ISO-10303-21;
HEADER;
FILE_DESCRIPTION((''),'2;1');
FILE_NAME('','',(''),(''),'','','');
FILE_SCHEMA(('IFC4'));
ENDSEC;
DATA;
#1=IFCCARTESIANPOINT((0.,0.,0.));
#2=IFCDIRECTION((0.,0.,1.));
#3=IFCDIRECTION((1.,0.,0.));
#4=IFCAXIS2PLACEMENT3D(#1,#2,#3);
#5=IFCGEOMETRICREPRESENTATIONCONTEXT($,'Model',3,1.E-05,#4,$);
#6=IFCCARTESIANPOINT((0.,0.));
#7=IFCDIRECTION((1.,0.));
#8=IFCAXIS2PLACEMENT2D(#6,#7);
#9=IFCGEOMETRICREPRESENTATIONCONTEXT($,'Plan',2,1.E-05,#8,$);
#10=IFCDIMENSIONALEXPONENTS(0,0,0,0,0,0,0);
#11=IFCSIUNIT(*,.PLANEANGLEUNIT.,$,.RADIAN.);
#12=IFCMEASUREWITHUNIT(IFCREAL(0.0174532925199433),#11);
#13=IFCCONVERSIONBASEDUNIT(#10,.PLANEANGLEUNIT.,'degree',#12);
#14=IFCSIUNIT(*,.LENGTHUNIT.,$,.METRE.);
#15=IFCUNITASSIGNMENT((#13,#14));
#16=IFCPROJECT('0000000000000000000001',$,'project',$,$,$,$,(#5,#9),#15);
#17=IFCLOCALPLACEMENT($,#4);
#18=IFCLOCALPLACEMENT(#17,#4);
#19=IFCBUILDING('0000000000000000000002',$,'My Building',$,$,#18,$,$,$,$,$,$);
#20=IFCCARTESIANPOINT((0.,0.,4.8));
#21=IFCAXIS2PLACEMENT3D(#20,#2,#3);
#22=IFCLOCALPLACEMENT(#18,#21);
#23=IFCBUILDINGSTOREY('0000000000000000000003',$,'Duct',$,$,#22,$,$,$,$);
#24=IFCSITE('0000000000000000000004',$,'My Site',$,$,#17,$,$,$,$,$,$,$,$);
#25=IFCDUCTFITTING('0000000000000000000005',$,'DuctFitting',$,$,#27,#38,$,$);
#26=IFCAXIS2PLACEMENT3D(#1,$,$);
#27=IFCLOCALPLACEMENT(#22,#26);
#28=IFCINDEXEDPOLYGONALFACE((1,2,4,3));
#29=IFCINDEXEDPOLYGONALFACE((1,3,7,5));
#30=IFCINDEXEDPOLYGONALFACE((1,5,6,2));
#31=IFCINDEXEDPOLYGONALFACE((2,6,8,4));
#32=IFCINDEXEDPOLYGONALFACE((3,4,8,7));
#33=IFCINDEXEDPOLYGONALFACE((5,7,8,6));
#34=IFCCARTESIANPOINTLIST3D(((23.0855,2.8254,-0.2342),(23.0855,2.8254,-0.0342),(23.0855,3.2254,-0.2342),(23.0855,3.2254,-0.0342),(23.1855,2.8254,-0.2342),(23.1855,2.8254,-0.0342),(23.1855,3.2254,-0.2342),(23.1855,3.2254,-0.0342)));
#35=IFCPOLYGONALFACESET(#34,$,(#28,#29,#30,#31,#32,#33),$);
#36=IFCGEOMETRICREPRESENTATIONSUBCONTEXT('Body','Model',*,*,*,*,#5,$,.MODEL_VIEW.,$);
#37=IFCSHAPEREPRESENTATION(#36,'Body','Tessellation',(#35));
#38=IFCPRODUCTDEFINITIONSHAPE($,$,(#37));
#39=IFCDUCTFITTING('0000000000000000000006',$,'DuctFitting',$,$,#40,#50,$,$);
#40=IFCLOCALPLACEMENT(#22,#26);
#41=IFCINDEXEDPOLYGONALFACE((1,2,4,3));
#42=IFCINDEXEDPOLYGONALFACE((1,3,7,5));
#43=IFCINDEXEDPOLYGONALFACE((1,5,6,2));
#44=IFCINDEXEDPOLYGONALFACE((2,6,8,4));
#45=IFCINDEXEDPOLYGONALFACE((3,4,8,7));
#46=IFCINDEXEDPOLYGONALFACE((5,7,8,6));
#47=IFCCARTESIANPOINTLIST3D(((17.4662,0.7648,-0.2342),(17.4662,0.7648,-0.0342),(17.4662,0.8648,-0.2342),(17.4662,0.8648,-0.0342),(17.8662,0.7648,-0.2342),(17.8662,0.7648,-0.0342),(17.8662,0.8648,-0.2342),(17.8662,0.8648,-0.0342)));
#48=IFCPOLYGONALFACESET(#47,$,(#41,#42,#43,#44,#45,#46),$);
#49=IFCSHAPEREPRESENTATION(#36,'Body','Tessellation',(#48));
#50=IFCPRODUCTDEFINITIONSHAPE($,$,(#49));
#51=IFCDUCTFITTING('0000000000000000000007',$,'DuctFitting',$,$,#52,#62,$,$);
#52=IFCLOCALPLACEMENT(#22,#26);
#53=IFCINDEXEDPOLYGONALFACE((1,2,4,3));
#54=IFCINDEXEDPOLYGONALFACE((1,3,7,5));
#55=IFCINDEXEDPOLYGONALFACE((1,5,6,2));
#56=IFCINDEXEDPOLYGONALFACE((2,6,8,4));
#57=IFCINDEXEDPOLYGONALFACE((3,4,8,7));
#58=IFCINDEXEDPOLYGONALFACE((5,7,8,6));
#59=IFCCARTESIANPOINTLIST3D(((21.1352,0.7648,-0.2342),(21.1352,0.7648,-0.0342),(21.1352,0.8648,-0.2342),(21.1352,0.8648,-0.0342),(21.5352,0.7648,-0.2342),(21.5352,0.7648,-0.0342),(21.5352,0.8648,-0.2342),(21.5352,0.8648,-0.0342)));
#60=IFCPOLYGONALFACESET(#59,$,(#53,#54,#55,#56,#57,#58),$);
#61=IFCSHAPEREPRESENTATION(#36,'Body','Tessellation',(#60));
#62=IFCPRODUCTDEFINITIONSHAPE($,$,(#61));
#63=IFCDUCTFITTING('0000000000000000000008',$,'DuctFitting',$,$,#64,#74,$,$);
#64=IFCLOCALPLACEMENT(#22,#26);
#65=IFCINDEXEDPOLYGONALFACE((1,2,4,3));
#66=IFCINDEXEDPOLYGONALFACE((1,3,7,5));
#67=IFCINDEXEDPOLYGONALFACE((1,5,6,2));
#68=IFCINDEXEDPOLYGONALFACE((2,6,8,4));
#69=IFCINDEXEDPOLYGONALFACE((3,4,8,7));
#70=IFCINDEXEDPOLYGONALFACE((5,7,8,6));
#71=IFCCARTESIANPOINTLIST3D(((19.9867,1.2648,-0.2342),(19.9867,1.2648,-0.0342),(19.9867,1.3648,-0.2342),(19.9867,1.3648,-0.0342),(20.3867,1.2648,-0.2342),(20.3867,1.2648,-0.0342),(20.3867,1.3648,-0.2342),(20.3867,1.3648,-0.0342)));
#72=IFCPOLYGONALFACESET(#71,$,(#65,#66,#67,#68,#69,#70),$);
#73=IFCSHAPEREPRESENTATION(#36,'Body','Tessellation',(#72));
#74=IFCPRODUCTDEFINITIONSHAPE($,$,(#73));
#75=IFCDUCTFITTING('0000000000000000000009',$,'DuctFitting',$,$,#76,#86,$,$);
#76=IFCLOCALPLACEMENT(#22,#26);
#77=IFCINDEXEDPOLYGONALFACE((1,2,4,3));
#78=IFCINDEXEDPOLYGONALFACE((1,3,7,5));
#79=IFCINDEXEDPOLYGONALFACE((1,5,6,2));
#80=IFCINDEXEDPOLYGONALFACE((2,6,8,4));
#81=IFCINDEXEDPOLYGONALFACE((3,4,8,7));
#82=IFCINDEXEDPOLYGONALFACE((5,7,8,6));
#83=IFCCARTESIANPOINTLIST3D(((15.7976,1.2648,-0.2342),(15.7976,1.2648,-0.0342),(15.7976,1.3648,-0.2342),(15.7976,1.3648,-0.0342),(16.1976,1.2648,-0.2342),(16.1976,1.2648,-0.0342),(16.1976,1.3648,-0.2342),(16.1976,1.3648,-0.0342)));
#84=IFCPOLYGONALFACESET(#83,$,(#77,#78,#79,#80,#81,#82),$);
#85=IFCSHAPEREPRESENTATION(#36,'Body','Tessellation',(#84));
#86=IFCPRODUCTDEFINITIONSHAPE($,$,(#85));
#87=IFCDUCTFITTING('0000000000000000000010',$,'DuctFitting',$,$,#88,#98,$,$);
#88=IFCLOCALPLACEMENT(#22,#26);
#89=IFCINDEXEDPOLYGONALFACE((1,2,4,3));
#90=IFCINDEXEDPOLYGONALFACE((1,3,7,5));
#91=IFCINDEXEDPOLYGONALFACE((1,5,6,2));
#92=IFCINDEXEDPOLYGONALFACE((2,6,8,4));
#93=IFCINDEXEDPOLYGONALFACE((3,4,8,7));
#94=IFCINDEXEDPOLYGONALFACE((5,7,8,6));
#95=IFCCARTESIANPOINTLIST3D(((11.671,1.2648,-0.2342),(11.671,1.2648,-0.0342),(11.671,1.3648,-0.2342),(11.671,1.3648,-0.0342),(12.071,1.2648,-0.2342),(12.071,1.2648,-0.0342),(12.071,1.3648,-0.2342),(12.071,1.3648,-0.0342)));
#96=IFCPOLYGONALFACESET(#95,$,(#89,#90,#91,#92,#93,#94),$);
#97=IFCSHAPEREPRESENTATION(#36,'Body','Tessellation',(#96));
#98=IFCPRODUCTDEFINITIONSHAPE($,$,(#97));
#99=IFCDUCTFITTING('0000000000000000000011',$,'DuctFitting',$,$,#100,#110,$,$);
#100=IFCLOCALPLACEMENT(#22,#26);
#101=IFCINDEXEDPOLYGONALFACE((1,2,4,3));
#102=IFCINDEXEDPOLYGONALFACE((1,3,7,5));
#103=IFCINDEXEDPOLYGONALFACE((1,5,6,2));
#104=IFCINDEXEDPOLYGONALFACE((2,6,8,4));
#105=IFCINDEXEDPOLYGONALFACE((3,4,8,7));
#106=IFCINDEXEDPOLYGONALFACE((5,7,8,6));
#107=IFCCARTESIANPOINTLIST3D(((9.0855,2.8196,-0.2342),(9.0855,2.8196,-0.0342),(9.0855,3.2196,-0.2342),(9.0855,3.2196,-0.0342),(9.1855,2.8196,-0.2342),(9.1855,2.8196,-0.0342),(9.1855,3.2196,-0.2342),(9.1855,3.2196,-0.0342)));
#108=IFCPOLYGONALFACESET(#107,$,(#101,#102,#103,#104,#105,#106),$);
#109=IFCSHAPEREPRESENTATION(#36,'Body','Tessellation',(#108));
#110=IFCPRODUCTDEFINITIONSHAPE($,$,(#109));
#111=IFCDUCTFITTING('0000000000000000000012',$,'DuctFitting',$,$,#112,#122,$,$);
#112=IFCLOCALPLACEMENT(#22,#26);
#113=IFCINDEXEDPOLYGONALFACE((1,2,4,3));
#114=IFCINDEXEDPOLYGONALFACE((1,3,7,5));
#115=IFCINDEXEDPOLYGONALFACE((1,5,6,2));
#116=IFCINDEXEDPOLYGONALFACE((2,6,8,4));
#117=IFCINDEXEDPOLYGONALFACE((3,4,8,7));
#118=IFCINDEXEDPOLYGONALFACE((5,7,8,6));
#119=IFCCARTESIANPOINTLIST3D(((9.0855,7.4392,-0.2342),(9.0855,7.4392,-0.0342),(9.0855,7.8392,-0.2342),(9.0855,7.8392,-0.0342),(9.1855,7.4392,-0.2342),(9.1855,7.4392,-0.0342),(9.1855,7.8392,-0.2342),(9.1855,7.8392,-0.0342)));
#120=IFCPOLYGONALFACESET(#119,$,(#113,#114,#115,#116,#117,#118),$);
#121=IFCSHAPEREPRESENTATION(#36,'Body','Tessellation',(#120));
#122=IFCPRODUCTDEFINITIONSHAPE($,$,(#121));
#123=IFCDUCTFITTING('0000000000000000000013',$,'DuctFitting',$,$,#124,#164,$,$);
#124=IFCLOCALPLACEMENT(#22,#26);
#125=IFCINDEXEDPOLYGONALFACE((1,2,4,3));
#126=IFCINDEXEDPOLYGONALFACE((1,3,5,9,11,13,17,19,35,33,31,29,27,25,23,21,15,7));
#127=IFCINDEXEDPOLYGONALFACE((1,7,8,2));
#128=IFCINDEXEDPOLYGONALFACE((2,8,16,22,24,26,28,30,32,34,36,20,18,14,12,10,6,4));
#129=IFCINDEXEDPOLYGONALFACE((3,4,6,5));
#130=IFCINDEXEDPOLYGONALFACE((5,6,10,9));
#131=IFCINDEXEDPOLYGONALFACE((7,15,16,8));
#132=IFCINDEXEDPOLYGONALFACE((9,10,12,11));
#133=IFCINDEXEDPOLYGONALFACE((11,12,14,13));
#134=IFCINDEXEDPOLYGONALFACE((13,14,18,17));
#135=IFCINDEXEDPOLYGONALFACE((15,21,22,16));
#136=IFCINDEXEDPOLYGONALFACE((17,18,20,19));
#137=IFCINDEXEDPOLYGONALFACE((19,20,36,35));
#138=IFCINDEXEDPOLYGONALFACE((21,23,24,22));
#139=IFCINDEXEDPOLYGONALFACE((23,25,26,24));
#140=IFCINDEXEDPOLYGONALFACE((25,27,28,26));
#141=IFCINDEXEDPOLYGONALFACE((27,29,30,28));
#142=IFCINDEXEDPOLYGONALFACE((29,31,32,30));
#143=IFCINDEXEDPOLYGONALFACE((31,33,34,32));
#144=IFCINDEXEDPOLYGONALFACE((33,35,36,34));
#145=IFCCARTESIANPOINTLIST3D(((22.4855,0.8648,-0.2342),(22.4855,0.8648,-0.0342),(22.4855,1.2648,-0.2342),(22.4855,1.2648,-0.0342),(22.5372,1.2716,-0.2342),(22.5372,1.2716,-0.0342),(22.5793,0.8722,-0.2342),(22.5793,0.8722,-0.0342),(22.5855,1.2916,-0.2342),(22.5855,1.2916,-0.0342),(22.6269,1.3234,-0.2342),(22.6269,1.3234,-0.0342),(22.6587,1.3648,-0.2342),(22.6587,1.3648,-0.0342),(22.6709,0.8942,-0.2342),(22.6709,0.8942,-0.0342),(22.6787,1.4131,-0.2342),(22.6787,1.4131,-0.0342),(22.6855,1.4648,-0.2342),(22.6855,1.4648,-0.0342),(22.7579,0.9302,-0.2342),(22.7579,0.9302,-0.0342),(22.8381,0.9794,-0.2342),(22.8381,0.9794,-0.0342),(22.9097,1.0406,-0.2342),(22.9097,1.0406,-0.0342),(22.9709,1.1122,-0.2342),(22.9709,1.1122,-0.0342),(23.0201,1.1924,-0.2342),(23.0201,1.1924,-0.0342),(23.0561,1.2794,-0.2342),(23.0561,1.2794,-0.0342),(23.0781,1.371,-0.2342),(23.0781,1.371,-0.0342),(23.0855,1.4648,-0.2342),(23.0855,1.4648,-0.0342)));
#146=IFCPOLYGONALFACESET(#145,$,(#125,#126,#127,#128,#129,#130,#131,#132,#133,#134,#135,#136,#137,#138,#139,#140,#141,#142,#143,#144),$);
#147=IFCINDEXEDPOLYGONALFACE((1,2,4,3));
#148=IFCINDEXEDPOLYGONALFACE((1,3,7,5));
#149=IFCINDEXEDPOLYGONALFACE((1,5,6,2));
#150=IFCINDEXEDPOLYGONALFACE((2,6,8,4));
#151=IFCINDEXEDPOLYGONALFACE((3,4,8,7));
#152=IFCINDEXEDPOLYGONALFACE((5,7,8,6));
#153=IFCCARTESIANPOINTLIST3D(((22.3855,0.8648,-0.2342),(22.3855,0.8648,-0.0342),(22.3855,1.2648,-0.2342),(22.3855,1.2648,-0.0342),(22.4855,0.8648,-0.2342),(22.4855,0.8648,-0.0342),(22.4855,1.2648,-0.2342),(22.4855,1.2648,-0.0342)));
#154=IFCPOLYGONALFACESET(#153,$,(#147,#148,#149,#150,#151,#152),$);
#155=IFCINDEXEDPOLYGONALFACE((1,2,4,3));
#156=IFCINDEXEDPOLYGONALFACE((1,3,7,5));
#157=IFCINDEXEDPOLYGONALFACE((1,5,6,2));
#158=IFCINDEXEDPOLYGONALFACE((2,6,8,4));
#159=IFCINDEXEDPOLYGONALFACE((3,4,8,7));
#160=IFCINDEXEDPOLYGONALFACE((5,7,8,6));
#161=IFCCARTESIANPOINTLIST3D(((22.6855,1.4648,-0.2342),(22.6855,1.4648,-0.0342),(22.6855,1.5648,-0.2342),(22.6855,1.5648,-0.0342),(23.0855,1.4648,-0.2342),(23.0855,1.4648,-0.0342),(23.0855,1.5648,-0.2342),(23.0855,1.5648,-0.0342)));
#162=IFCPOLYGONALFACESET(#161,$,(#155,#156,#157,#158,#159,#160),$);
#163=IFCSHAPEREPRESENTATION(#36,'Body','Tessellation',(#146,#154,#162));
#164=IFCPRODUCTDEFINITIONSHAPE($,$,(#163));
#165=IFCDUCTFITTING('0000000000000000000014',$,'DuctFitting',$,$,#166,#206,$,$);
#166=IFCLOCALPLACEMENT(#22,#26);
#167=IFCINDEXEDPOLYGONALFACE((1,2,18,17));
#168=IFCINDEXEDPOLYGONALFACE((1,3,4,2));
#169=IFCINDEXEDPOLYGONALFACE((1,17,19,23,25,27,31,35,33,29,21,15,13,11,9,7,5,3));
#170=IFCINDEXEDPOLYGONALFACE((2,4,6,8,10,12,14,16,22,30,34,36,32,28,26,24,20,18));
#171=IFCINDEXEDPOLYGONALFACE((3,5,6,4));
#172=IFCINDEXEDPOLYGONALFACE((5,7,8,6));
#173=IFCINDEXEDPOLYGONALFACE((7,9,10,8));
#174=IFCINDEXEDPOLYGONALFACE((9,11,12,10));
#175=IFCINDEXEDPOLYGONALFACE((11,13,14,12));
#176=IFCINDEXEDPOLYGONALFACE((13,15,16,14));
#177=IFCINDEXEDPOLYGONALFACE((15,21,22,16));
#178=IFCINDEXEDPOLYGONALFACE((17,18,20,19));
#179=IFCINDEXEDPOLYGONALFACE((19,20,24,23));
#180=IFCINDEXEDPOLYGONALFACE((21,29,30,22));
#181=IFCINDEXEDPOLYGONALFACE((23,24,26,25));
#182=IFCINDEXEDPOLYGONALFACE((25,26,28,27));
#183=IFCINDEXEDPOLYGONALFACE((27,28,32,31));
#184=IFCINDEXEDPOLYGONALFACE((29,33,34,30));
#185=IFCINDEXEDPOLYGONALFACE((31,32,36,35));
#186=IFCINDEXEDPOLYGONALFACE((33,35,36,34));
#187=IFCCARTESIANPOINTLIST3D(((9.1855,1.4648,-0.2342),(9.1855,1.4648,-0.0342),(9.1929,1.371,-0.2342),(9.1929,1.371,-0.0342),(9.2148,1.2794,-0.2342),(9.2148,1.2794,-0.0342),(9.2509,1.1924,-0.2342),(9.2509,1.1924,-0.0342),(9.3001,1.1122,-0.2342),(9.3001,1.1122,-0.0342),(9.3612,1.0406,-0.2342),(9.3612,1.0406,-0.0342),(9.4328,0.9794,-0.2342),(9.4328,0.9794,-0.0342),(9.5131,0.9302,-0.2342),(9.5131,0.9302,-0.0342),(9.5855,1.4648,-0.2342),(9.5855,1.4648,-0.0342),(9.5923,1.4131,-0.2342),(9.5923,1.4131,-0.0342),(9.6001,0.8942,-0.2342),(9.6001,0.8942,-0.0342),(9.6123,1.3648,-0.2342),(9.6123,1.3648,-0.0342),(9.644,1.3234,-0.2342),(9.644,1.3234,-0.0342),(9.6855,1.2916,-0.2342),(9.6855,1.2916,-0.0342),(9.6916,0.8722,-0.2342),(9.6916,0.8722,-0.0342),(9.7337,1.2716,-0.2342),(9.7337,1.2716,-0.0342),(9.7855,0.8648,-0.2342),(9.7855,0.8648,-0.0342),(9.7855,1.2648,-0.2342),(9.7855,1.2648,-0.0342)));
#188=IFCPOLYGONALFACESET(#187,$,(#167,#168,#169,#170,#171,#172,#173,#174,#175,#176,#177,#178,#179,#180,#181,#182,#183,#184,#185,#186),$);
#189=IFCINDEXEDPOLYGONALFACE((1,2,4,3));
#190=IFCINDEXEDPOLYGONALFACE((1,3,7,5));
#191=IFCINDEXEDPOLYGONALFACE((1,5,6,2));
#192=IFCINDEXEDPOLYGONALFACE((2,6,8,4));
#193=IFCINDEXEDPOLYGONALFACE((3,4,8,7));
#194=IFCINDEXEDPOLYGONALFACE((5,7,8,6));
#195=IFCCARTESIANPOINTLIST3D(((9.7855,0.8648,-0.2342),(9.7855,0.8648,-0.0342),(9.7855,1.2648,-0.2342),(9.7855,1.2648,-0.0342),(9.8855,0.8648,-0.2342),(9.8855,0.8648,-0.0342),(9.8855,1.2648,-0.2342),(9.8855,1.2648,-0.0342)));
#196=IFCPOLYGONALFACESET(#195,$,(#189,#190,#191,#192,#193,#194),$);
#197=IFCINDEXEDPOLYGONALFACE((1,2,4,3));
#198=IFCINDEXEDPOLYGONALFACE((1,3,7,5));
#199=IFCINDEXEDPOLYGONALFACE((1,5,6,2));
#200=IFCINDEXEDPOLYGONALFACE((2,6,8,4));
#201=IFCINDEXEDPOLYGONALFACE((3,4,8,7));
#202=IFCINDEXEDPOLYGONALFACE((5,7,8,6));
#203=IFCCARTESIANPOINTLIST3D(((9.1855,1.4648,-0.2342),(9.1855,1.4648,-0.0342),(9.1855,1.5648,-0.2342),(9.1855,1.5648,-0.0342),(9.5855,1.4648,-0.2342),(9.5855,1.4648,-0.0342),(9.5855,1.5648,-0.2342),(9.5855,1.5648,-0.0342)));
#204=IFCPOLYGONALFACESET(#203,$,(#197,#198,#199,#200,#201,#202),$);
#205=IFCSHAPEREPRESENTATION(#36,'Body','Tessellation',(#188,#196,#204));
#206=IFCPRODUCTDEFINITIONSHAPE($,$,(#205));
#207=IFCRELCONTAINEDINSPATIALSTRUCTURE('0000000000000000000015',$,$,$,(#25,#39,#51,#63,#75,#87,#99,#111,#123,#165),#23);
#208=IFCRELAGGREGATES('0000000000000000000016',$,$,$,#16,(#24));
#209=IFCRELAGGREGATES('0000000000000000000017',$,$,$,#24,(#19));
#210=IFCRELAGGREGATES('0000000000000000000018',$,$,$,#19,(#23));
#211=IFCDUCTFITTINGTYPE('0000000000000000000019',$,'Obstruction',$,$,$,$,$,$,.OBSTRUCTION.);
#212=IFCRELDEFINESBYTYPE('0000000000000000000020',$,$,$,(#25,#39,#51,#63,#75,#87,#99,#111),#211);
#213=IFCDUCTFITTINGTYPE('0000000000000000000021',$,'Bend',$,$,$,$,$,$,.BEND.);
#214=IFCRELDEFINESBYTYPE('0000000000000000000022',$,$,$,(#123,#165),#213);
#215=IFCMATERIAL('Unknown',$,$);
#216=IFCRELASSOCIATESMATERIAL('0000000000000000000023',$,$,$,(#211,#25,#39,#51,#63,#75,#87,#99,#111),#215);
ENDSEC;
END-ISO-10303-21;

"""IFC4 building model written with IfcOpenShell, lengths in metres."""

from ifc_helpers import new_model, entity, si_unit, converted_unit, frame, origin_with_axes, origin_2d_with_axis, place, context, subcontext, project, spatial, line, arc, indexed_curve, rectangle, outline, extrude, source, transform, mapped, material, material_profile, profile_set, profile_usage, type_object, type_shapes, element, save


model = new_model("IFC4")

# Units and contexts
model_context = context("Model", 3, precision=1e-05, world=origin_with_axes())
plan_context = context("Plan", 2, precision=1e-05, world=origin_2d_with_axis())
body_context = subcontext(model_context, "Body", "Model", "MODEL_VIEW")
ifc_project = project(units=[converted_unit("PLANEANGLEUNIT", "degree", entity("IfcReal", 0.0174532925199433), si_unit("PLANEANGLEUNIT", "RADIAN"), dimensions=[0, 0, 0, 0, 0, 0, 0]), si_unit("LENGTHUNIT", "METRE")], contexts=[model_context, plan_context])

# Site, building, storey
site_placement = place(None, origin_with_axes())
site = spatial("IfcSite", under=ifc_project, at=site_placement, Name="My Site")
building_placement = place(site_placement, origin_with_axes())
building = spatial("IfcBuilding", under=site, at=building_placement, Name="My Building")
storey_placement = place(building_placement, frame((0.0, 0.0, 4.8), z_axis=(0.0, 0.0, 1.0), x_axis=(1.0, 0.0, 0.0)))
storey = spatial("IfcBuildingStorey", under=building, at=storey_placement, Name="Duct")

# Shared definitions
ifc_material = material(Name="Unknown")

# Duct fittings
ifc_material_profile_1 = material_profile(ifc_material, rectangle(XDim=0.4, YDim=0.2))
ifc_profile_set_1 = profile_set([ifc_material_profile_1])
duct_fitting_type_1 = type_object("IfcDuctFittingType", Name="Obstruction", PredefinedType="OBSTRUCTION", material=ifc_profile_set_1)
ifc_profile_usage_1 = profile_usage(ifc_profile_set_1, cardinal=5)
duct_fitting_1_placement = place(storey_placement, frame((23.0855, 3.0254, -0.1342), z_axis=(1.0, -0.000001, 0.000001), x_axis=(0.000001, 1.0, 0.0)))
element("IfcDuctFitting", 1, at=duct_fitting_1_placement, inside=storey, type_object=duct_fitting_type_1, material=ifc_profile_usage_1, Name="DuctFitting", context=body_context, shape_type="SweptSolid", body=[
    extrude(rectangle(XDim=0.4, YDim=0.2), origin_with_axes(), (0.0, 0.0, 1.0), 0.1),
])
ifc_profile_usage_2 = profile_usage(ifc_profile_set_1, cardinal=5)
duct_fitting_2_placement = place(storey_placement, frame((17.6662, 0.8648, -0.1342), z_axis=(0.0, -1.0, -0.000001), x_axis=(1.0, 0.0, 0.0)))
element("IfcDuctFitting", 2, at=duct_fitting_2_placement, inside=storey, type_object=duct_fitting_type_1, material=ifc_profile_usage_2, Name="DuctFitting", context=body_context, shape_type="SweptSolid", body=[
    extrude(rectangle(XDim=0.4, YDim=0.2), origin_with_axes(), (0.0, 0.0, 1.0), 0.1),
])
ifc_profile_usage_3 = profile_usage(ifc_profile_set_1, cardinal=5)
duct_fitting_3_placement = place(storey_placement, frame((21.3352, 0.8648, -0.1342), z_axis=(0.0, -1.0, -0.000001), x_axis=(1.0, 0.0, 0.0)))
element("IfcDuctFitting", 3, at=duct_fitting_3_placement, inside=storey, type_object=duct_fitting_type_1, material=ifc_profile_usage_3, Name="DuctFitting", context=body_context, shape_type="SweptSolid", body=[
    extrude(rectangle(XDim=0.4, YDim=0.2), origin_with_axes(), (0.0, 0.0, 1.0), 0.1),
])
ifc_profile_usage_4 = profile_usage(ifc_profile_set_1, cardinal=5)
duct_fitting_4_placement = place(storey_placement, frame((20.1867, 1.3648, -0.1342), z_axis=(0.000001, -1.0, 0.0), x_axis=(1.0, 0.000001, 0.0)))
element("IfcDuctFitting", 4, at=duct_fitting_4_placement, inside=storey, type_object=duct_fitting_type_1, material=ifc_profile_usage_4, Name="DuctFitting", context=body_context, shape_type="SweptSolid", body=[
    extrude(rectangle(XDim=0.4, YDim=0.2), origin_with_axes(), (0.0, 0.0, 1.0), 0.1),
])
ifc_profile_usage_5 = profile_usage(ifc_profile_set_1, cardinal=5)
duct_fitting_5_placement = place(storey_placement, frame((15.9976, 1.3648, -0.1342), z_axis=(0.000001, -1.0, 0.0), x_axis=(1.0, 0.000001, 0.0)))
element("IfcDuctFitting", 5, at=duct_fitting_5_placement, inside=storey, type_object=duct_fitting_type_1, material=ifc_profile_usage_5, Name="DuctFitting", context=body_context, shape_type="SweptSolid", body=[
    extrude(rectangle(XDim=0.4, YDim=0.2), origin_with_axes(), (0.0, 0.0, 1.0), 0.1),
])
ifc_profile_usage_6 = profile_usage(ifc_profile_set_1, cardinal=5)
duct_fitting_6_placement = place(storey_placement, frame((11.871, 1.3648, -0.1342), z_axis=(0.000001, -1.0, 0.0), x_axis=(1.0, 0.000001, 0.0)))
element("IfcDuctFitting", 6, at=duct_fitting_6_placement, inside=storey, type_object=duct_fitting_type_1, material=ifc_profile_usage_6, Name="DuctFitting", context=body_context, shape_type="SweptSolid", body=[
    extrude(rectangle(XDim=0.4, YDim=0.2), origin_with_axes(), (0.0, 0.0, 1.0), 0.1),
])
ifc_profile_usage_7 = profile_usage(ifc_profile_set_1, cardinal=5)
duct_fitting_7_placement = place(storey_placement, frame((9.1855, 3.0196, -0.1342), z_axis=(-1.0, 0.0, 0.0), x_axis=(0.0, -1.0, 0.0)))
element("IfcDuctFitting", 7, at=duct_fitting_7_placement, inside=storey, type_object=duct_fitting_type_1, material=ifc_profile_usage_7, Name="DuctFitting", context=body_context, shape_type="SweptSolid", body=[
    extrude(rectangle(XDim=0.4, YDim=0.2), origin_with_axes(), (0.0, 0.0, 1.0), 0.1),
])
ifc_profile_usage_8 = profile_usage(ifc_profile_set_1, cardinal=5)
duct_fitting_8_placement = place(storey_placement, frame((9.1855, 7.6392, -0.1342), z_axis=(-1.0, 0.0, 0.0), x_axis=(0.0, -1.0, 0.0)))
element("IfcDuctFitting", 8, at=duct_fitting_8_placement, inside=storey, type_object=duct_fitting_type_1, material=ifc_profile_usage_8, Name="DuctFitting", context=body_context, shape_type="SweptSolid", body=[
    extrude(rectangle(XDim=0.4, YDim=0.2), origin_with_axes(), (0.0, 0.0, 1.0), 0.1),
])
duct_fitting_type_2 = type_object("IfcDuctFittingType", Name="Bend", PredefinedType="BEND")
shared_shape = source(origin_with_axes(), body_context, "Body", "SweptSolid", [
    extrude(outline(indexed_curve([(-0.2, 0.0), (-0.2586, -0.1414), (-0.4, -0.2), (-0.4, -0.6), (0.0243, -0.4243), (0.2, 0.0)], segments=[arc(1, 2, 3), line(3, 4), arc(4, 5, 6), line(6, 1)])), frame((0.0, -0.1, -0.1), z_axis=(0.0, -1.0, 0.0), x_axis=(1.0, 0.0, 0.0)), (0.0, 0.0, -1.0), 0.2),
    extrude(rectangle(XDim=0.4, YDim=0.2), origin_with_axes(), (0.0, 0.0, -1.0), 0.1),
    extrude(rectangle(XDim=0.4, YDim=0.2), frame((-0.4, 0.0, -0.5), z_axis=(-1.0, 0.0, 0.0), x_axis=(0.0, 0.0, -1.0)), (0.0, 0.0, 1.0), 0.1),
])
type_shapes(duct_fitting_type_2, [shared_shape])
for number, where, z_axis, x_axis, name in (
    (9, (22.3855, 1.0648, -0.1342), (-1.0, 0.0, 0.0), (0.0, -1.0, 0.0), "DuctFitting"),
    (10, (9.8855, 1.0648, -0.1342), (1.0, 0.0, 0.0), (0.0, -1.0, 0.0), "DuctFitting"),
):
    element("IfcDuctFitting", number, at=place(storey_placement, frame(where, z_axis=z_axis, x_axis=x_axis)), inside=storey, type_object=duct_fitting_type_2, Name=name, context=body_context, shape_type="MappedRepresentation", body=[
        mapped(shared_shape, transform((0.0, 0.0, 0.0), x_axis=(1.0, 0.0, 0.0), y_axis=(0.0, 1.0, 0.0), z_axis=(0.0, 0.0, 1.0), scale=1.0)),
    ])

save(model, "model.ifc")
